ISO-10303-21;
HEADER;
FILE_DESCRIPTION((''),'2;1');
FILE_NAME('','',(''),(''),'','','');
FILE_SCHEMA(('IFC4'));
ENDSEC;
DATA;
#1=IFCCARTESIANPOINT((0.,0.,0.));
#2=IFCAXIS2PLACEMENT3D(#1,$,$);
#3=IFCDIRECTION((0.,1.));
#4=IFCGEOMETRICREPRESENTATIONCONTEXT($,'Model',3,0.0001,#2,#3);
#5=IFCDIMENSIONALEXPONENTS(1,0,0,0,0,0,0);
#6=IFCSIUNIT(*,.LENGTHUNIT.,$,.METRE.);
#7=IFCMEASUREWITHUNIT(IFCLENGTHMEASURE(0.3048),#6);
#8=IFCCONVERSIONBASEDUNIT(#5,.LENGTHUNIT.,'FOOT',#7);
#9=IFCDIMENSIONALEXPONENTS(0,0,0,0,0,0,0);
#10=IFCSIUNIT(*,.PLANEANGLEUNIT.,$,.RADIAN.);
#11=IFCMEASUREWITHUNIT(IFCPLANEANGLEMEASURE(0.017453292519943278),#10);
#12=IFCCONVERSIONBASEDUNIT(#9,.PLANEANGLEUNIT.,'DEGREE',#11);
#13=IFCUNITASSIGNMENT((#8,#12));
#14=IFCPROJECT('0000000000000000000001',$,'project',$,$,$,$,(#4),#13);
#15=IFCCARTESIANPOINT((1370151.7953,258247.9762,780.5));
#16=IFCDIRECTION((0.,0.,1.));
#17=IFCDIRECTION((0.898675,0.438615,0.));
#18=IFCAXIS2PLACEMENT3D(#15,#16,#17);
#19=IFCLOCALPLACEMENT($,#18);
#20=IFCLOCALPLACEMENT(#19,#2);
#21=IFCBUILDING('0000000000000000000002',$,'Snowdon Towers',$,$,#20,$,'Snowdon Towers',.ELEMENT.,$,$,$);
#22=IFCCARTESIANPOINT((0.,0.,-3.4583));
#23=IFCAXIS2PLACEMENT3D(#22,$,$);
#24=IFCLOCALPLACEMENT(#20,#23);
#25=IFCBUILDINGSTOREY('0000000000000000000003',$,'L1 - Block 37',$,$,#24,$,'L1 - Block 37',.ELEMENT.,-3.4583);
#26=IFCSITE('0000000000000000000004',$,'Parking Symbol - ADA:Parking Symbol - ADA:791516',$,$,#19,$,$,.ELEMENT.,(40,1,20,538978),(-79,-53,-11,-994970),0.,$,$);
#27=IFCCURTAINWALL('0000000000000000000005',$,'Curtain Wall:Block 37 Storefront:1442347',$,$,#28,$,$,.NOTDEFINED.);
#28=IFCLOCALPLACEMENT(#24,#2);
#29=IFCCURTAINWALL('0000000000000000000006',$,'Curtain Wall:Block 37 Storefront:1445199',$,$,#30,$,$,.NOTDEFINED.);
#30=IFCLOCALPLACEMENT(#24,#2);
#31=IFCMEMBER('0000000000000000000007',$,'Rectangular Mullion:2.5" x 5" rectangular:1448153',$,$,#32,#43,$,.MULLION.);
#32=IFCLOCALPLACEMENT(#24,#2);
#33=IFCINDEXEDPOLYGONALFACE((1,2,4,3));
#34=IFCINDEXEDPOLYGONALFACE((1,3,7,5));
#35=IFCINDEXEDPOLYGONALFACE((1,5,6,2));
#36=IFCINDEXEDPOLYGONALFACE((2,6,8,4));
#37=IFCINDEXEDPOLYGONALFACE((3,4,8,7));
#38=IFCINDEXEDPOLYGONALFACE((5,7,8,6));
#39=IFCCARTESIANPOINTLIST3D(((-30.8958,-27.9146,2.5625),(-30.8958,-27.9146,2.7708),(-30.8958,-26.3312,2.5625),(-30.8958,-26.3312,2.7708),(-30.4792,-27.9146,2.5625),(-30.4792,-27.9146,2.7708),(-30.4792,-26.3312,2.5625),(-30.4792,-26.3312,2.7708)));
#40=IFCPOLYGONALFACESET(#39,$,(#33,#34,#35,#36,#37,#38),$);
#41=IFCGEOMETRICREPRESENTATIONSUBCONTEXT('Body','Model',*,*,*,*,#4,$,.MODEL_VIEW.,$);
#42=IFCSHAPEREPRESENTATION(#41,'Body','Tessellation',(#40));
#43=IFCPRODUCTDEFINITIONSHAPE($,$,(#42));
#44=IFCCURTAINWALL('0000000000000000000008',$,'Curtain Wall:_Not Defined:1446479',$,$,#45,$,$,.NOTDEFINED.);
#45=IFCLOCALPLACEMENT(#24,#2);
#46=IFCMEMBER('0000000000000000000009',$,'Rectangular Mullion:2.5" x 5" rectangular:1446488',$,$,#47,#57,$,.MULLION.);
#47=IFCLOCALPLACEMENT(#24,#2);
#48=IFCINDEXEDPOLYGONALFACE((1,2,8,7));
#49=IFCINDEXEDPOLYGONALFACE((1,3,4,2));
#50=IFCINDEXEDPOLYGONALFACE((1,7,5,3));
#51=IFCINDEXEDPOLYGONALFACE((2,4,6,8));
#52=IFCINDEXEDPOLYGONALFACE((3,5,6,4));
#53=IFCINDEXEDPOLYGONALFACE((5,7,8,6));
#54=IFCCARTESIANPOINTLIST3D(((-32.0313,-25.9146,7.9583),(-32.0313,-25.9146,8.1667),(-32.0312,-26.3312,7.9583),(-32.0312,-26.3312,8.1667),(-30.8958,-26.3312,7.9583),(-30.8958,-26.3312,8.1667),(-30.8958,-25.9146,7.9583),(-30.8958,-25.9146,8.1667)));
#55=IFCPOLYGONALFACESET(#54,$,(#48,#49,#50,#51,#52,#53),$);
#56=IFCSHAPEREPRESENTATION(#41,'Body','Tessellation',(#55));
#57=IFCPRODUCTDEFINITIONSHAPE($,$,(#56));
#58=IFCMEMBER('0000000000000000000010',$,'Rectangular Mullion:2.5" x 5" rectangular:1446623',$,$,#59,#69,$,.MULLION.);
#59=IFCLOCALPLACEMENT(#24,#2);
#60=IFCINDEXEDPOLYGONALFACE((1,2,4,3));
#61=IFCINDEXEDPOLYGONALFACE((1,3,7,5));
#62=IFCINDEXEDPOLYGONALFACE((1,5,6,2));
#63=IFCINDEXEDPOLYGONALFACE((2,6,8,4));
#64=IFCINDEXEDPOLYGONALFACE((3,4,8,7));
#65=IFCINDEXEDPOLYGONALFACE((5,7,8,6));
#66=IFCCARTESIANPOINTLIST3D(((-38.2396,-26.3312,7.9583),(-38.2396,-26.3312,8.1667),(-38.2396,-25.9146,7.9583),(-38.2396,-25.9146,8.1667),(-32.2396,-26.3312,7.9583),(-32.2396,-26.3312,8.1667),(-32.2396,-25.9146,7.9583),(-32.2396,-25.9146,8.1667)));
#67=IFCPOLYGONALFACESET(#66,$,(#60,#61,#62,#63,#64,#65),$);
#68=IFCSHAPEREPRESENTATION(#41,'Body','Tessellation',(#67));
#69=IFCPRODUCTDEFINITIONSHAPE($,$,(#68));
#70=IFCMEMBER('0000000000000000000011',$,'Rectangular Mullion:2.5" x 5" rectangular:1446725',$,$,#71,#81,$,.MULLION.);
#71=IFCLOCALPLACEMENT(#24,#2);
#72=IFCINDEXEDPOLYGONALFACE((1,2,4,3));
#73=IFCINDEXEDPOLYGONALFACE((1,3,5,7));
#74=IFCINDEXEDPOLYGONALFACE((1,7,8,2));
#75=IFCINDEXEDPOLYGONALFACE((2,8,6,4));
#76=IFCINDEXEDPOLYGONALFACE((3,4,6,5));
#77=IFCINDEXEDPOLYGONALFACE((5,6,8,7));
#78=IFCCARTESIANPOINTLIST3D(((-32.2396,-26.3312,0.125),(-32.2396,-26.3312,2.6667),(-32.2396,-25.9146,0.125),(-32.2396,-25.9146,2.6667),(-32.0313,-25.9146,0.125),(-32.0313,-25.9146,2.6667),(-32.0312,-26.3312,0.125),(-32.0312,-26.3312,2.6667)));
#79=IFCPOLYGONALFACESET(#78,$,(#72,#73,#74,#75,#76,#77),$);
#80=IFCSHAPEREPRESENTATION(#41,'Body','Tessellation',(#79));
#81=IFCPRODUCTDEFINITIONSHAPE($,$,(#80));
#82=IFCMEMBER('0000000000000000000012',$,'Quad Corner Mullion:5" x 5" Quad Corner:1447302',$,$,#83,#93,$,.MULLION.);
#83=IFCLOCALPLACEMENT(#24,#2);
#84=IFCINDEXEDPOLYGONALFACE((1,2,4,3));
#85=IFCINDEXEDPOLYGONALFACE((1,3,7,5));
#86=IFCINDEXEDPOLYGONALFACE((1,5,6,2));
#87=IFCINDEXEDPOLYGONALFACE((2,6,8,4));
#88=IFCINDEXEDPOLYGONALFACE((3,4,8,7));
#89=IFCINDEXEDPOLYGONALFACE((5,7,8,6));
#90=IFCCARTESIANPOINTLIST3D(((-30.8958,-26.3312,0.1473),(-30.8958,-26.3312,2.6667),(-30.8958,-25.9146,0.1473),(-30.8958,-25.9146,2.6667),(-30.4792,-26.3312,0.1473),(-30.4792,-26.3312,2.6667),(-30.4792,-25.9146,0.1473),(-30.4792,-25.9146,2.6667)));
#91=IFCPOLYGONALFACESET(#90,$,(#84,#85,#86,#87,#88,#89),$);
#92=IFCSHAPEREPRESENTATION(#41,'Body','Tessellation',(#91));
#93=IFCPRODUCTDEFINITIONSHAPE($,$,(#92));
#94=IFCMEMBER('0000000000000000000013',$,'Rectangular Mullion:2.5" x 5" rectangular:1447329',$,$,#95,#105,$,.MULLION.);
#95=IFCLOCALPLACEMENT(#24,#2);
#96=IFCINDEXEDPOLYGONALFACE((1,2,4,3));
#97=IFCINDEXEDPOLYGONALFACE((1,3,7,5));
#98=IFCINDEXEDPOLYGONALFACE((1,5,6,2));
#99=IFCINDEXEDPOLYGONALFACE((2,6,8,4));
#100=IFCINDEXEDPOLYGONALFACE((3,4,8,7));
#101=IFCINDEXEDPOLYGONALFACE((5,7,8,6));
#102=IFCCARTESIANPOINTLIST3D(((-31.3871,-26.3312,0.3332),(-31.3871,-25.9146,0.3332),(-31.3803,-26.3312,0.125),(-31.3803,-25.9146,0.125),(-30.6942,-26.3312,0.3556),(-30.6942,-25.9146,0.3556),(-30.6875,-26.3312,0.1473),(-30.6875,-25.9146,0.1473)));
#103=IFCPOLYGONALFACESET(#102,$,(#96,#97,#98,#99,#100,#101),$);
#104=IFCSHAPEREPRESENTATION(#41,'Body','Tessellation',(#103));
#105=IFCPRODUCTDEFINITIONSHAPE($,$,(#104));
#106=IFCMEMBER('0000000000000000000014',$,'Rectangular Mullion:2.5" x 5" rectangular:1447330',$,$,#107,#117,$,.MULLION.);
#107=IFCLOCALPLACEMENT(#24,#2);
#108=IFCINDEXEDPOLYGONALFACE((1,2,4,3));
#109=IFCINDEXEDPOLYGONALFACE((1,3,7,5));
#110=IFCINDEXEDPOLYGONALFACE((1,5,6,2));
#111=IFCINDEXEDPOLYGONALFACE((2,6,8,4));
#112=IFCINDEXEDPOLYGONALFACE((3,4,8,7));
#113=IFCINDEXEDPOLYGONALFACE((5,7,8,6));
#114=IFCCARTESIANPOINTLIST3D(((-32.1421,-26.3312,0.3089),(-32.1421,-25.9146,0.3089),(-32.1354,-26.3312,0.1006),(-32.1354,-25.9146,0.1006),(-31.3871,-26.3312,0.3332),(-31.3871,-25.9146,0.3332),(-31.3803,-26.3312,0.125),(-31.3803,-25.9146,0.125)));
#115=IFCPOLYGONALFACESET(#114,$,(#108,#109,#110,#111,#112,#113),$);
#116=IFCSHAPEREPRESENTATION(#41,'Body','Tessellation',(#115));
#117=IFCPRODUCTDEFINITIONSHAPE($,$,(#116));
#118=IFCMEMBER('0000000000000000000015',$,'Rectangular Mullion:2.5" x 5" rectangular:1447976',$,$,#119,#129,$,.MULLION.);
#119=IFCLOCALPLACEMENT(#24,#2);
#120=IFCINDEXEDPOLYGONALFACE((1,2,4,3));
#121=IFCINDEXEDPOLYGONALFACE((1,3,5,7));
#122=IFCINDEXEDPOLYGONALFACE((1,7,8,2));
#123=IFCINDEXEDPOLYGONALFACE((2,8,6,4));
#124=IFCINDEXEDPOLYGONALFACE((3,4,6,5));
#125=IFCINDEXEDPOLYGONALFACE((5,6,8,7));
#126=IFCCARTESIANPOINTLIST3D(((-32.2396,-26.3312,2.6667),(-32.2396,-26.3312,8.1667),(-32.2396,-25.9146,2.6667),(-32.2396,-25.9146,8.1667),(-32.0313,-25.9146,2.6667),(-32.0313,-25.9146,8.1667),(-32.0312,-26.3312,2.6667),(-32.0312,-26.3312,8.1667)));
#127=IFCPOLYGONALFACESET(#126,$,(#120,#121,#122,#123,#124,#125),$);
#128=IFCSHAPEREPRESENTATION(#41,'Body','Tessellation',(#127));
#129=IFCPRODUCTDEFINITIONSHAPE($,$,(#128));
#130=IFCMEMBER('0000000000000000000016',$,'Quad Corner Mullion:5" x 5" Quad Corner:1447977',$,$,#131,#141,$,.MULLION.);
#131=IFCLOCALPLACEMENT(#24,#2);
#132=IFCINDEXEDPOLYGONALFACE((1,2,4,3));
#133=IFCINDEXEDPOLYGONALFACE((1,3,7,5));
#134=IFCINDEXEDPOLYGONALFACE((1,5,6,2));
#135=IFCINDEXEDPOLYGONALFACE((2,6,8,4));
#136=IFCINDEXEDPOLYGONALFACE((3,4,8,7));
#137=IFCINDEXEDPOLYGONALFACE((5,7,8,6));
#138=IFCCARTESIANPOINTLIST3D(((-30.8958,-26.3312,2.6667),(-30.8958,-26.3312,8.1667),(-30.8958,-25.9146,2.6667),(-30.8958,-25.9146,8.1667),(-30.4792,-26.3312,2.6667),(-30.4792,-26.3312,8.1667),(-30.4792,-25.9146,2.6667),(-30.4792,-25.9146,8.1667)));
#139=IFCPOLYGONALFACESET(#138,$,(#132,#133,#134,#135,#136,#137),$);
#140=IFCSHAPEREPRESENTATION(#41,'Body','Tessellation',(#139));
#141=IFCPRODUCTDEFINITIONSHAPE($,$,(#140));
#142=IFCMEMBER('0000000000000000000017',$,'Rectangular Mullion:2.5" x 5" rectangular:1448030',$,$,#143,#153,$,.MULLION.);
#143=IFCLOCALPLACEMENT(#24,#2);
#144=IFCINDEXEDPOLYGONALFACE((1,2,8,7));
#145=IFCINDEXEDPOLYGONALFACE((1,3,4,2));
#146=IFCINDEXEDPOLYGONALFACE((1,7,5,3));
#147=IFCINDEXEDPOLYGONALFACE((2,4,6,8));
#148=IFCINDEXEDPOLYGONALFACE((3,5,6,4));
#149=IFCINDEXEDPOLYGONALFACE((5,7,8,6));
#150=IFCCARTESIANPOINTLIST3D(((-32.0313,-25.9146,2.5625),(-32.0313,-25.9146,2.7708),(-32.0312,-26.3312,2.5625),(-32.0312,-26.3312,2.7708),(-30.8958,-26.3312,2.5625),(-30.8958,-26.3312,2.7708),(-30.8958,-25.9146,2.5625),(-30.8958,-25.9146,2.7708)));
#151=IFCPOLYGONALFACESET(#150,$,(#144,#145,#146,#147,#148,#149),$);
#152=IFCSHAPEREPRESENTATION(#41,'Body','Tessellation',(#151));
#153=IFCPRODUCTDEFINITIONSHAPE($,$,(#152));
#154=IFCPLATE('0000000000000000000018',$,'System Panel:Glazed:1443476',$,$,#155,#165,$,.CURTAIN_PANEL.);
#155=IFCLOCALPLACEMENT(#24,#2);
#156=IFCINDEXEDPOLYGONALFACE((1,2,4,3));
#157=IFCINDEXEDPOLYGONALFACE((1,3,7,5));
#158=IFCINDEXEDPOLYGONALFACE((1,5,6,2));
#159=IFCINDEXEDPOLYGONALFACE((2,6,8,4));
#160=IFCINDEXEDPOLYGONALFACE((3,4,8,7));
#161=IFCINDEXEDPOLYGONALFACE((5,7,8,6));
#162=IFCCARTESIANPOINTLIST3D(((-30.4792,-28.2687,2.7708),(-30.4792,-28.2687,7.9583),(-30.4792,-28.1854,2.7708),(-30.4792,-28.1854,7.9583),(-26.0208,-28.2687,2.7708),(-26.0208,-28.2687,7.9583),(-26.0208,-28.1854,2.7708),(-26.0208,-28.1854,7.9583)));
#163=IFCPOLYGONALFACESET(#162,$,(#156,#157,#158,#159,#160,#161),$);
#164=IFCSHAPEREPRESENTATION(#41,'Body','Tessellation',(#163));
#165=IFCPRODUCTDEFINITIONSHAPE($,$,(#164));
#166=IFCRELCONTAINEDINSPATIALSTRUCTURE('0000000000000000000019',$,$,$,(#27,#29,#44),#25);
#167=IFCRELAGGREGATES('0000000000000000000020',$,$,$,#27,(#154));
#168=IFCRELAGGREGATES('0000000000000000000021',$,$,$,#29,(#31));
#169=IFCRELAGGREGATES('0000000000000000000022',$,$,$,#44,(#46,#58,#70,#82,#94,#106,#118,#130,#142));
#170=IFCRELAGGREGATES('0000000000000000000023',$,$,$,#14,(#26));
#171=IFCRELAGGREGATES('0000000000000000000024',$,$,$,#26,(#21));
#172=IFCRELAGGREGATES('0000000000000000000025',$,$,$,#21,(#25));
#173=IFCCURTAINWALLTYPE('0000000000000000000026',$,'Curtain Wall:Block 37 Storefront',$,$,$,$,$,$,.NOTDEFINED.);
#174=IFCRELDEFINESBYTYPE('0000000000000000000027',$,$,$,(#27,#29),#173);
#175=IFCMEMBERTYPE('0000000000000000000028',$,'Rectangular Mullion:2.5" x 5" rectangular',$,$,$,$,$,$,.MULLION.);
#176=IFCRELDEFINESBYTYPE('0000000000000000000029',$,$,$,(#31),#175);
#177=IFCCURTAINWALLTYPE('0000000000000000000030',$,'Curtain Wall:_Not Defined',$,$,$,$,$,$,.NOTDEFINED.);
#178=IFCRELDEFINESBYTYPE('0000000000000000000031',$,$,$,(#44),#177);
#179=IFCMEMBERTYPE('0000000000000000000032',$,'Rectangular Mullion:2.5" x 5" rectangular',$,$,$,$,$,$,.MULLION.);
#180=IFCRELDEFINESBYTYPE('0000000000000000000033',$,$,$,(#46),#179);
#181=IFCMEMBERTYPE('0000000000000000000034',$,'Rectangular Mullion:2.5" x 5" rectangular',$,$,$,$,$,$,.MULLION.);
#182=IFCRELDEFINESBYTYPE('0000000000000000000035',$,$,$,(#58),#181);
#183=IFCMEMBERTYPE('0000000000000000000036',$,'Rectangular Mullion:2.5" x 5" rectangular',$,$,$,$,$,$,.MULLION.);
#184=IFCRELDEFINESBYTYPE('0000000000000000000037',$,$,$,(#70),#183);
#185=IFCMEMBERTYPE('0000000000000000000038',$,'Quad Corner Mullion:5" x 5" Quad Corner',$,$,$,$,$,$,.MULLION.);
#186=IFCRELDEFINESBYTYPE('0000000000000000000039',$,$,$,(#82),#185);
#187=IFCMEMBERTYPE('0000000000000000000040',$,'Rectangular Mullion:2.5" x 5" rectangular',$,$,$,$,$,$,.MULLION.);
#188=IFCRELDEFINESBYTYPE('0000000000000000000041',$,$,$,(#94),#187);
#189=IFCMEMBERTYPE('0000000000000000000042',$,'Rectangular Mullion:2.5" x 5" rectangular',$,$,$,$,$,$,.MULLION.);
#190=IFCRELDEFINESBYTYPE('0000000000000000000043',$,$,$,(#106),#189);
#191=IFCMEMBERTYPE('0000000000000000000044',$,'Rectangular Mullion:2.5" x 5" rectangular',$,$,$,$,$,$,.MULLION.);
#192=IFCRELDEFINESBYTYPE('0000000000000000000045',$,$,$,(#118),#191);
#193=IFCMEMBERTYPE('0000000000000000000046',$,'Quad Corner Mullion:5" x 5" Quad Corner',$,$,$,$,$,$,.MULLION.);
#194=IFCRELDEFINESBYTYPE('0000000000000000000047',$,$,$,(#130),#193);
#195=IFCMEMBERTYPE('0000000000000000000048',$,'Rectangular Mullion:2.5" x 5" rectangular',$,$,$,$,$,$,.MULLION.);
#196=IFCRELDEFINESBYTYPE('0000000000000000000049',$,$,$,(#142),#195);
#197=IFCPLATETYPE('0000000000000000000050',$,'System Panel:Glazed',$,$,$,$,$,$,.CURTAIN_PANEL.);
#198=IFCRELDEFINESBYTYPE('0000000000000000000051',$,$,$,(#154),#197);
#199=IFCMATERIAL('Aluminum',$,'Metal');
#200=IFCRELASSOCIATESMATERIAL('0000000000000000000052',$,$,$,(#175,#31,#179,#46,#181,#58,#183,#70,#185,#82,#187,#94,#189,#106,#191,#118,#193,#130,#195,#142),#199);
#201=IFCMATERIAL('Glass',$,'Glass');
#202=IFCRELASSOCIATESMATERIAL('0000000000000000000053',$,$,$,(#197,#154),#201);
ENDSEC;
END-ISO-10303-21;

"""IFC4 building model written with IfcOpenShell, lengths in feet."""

from ifc_helpers import new_model, entity, si_unit, converted_unit, direction, frame, origin, place, context, subcontext, project, spatial, indexed_curve, outline, extrude, source, transform, mapped, material, type_object, type_shapes, element, aggregate, save


model = new_model("IFC4")

# Units and contexts
model_context = context("Model", 3, precision=0.0001, world=origin(), true_north=direction((0.0, 1.0)))
body_context = subcontext(model_context, "Body", "Model", "MODEL_VIEW")
ifc_project = project(units=[converted_unit("LENGTHUNIT", "FOOT", entity("IfcLengthMeasure", 0.3048), si_unit("LENGTHUNIT", "METRE"), dimensions=[1, 0, 0, 0, 0, 0, 0]), converted_unit("PLANEANGLEUNIT", "DEGREE", entity("IfcPlaneAngleMeasure", 0.017453292519943278), si_unit("PLANEANGLEUNIT", "RADIAN"), dimensions=[0, 0, 0, 0, 0, 0, 0])], contexts=[model_context])

# Site, building, storey
site_placement = place(None, frame((1370151.7953, 258247.9762, 780.5), z_axis=(0.0, 0.0, 1.0), x_axis=(0.898675, 0.438615, 0.0)))
site = spatial("IfcSite", under=ifc_project, at=site_placement, Name="Parking Symbol - ADA:Parking Symbol - ADA:791516", CompositionType="ELEMENT", RefLatitude=(40, 1, 20, 538978), RefLongitude=(-79, -53, -11, -994970), RefElevation=0.0)
building_placement = place(site_placement, origin())
building = spatial("IfcBuilding", under=site, at=building_placement, Name="Snowdon Towers", LongName="Snowdon Towers", CompositionType="ELEMENT")
storey_placement = place(building_placement, frame((0.0, 0.0, -3.4583)))
storey = spatial("IfcBuildingStorey", under=building, at=storey_placement, Name="L1 - Block 37", LongName="L1 - Block 37", CompositionType="ELEMENT", Elevation=-3.4583)

# Curtain walls, members
curtain_wall_type_1 = type_object("IfcCurtainWallType", Name="Curtain Wall:Block 37 Storefront", PredefinedType="NOTDEFINED")
curtain_wall_1_placement = place(storey_placement, frame((0.0, 0.0, 3.4583)))
curtain_wall_1 = element("IfcCurtainWall", 1, at=curtain_wall_1_placement, inside=storey, type_object=curtain_wall_type_1, Name="Curtain Wall:Block 37 Storefront:1442347", PredefinedType="NOTDEFINED")
ifc_material_1 = material(Name="Aluminum", Category="Metal")
curtain_wall_2_placement = place(storey_placement, frame((0.0, 0.0, 3.4583)))
curtain_wall_2 = element("IfcCurtainWall", 2, at=curtain_wall_2_placement, inside=storey, type_object=curtain_wall_type_1, Name="Curtain Wall:Block 37 Storefront:1445199", PredefinedType="NOTDEFINED")
member_type_1 = type_object("IfcMemberType", Name="Rectangular Mullion:2.5\" x 5\" rectangular", PredefinedType="MULLION", material=ifc_material_1)
shared_shape_1 = source(origin(), body_context, "Body", "SweptSolid", [
    extrude(outline(indexed_curve([(-0.1042, -0.2083), (0.1042, -0.2083), (0.1042, 0.2083), (-0.1042, 0.2083), (-0.1042, -0.2083)], self_intersect=False)), frame((0.0, 0.0, -1.5833), z_axis=(0.0, 0.0, 1.0), x_axis=(-1.0, 0.0, 0.0)), (0.0, 0.0, 1.0), 1.5833),
])
type_shapes(member_type_1, [shared_shape_1])
member_1_placement = place(curtain_wall_2_placement, frame((-30.6875, -27.9146, -0.7917), z_axis=(0.0, -1.0, 0.0), x_axis=(0.0, 0.0, 1.0)))
member_1 = element("IfcMember", 3, at=member_1_placement, type_object=member_type_1, material=ifc_material_1, Name="Rectangular Mullion:2.5\" x 5\" rectangular:1448153", PredefinedType="MULLION", context=body_context, shape_type="MappedRepresentation", body=[
    mapped(shared_shape_1, transform((0.0, 0.0, 0.0), scale=1.0)),
])
curtain_wall_type_2 = type_object("IfcCurtainWallType", Name="Curtain Wall:_Not Defined", PredefinedType="NOTDEFINED")
curtain_wall_3_placement = place(storey_placement, frame((0.0, 0.0, 3.4583)))
curtain_wall_3 = element("IfcCurtainWall", 4, at=curtain_wall_3_placement, inside=storey, type_object=curtain_wall_type_2, Name="Curtain Wall:_Not Defined:1446479", PredefinedType="NOTDEFINED")
member_type_2 = type_object("IfcMemberType", Name="Rectangular Mullion:2.5\" x 5\" rectangular", PredefinedType="MULLION", material=ifc_material_1)
shared_shape_2 = source(origin(), body_context, "Body", "SweptSolid", [
    extrude(outline(indexed_curve([(-0.1042, -0.2083), (0.1042, -0.2083), (0.1042, 0.2083), (-0.1042, 0.2083), (-0.1042, -0.2083)], self_intersect=False)), frame((-0.1042, 0.0, -1.1354), z_axis=(0.0, 0.0, 1.0), x_axis=(-1.0, 0.0, 0.0)), (0.0, 0.0, 1.0), 1.1354),
])
type_shapes(member_type_2, [shared_shape_2])
member_2_placement = place(curtain_wall_3_placement, frame((-30.8958, -26.1229, 4.7083), z_axis=(1.0, 0.0, 0.0), x_axis=(0.0, 0.0, 1.0)))
member_2 = element("IfcMember", 5, at=member_2_placement, type_object=member_type_2, material=ifc_material_1, Name="Rectangular Mullion:2.5\" x 5\" rectangular:1446488", PredefinedType="MULLION", context=body_context, shape_type="MappedRepresentation", body=[
    mapped(shared_shape_2, transform((0.0, 0.0, 0.0), scale=1.0)),
])
member_type_3 = type_object("IfcMemberType", Name="Rectangular Mullion:2.5\" x 5\" rectangular", PredefinedType="MULLION", material=ifc_material_1)
shared_shape_3 = source(origin(), body_context, "Body", "SweptSolid", [
    extrude(outline(indexed_curve([(-0.1042, -0.2083), (0.1042, -0.2083), (0.1042, 0.2083), (-0.1042, 0.2083), (-0.1042, -0.2083)], self_intersect=False)), frame((-0.1042, 0.0, -6.0), z_axis=(0.0, 0.0, 1.0), x_axis=(-1.0, 0.0, 0.0)), (0.0, 0.0, 1.0), 6.0),
])
type_shapes(member_type_3, [shared_shape_3])
member_3_placement = place(curtain_wall_3_placement, frame((-32.2396, -26.1229, 4.7083), z_axis=(1.0, 0.0, 0.0), x_axis=(0.0, 0.0, 1.0)))
member_3 = element("IfcMember", 6, at=member_3_placement, type_object=member_type_3, material=ifc_material_1, Name="Rectangular Mullion:2.5\" x 5\" rectangular:1446623", PredefinedType="MULLION", context=body_context, shape_type="MappedRepresentation", body=[
    mapped(shared_shape_3, transform((0.0, 0.0, 0.0), scale=1.0)),
])
member_type_4 = type_object("IfcMemberType", Name="Rectangular Mullion:2.5\" x 5\" rectangular", PredefinedType="MULLION", material=ifc_material_1)
shared_shape_4 = source(origin(), body_context, "Body", "SweptSolid", [
    extrude(outline(indexed_curve([(-0.1042, -0.2083), (0.1042, -0.2083), (0.1042, 0.2083), (-0.1042, 0.2083), (-0.1042, -0.2083)], self_intersect=False)), frame((0.0, 0.0, -2.5417), z_axis=(0.0, 0.0, 1.0), x_axis=(-1.0, 0.0, 0.0)), (0.0, 0.0, 1.0), 2.5417),
])
type_shapes(member_type_4, [shared_shape_4])
member_4_placement = place(curtain_wall_3_placement, frame((-32.1354, -26.1229, -3.3333), z_axis=(0.0, 0.0, -1.0), x_axis=(1.0, 0.0, 0.0)))
member_4 = element("IfcMember", 7, at=member_4_placement, type_object=member_type_4, material=ifc_material_1, Name="Rectangular Mullion:2.5\" x 5\" rectangular:1446725", PredefinedType="MULLION", context=body_context, shape_type="MappedRepresentation", body=[
    mapped(shared_shape_4, transform((0.0, 0.0, 0.0), scale=1.0)),
])
member_type_5 = type_object("IfcMemberType", Name="Quad Corner Mullion:5\" x 5\" Quad Corner", PredefinedType="MULLION", material=ifc_material_1)
shared_shape_5 = source(origin(), body_context, "Body", "SweptSolid", [
    extrude(outline(indexed_curve([(-0.2083, -0.2083), (0.2083, -0.2083), (0.2083, 0.2083), (-0.2083, 0.2083), (-0.2083, -0.2083)], self_intersect=False)), frame((0.0, 0.0, -2.5193), z_axis=(0.0, 0.0, 1.0), x_axis=(-1.0, 0.0, 0.0)), (0.0, 0.0, 1.0), 2.5193),
])
type_shapes(member_type_5, [shared_shape_5])
member_5_placement = place(curtain_wall_3_placement, frame((-30.6875, -26.1229, -3.311), z_axis=(0.0, 0.0, -1.0), x_axis=(1.0, 0.0, 0.0)))
member_5 = element("IfcMember", 8, at=member_5_placement, type_object=member_type_5, material=ifc_material_1, Name="Quad Corner Mullion:5\" x 5\" Quad Corner:1447302", PredefinedType="MULLION", context=body_context, shape_type="MappedRepresentation", body=[
    mapped(shared_shape_5, transform((0.0, 0.0, 0.0), scale=1.0)),
])
member_type_6 = type_object("IfcMemberType", Name="Rectangular Mullion:2.5\" x 5\" rectangular", PredefinedType="MULLION", material=ifc_material_1)
shared_shape_6 = source(origin(), body_context, "Body", "SweptSolid", [
    extrude(outline(indexed_curve([(-0.3466, -0.2083), (0.3466, -0.2083), (0.3466, 0.2083), (-0.3466, 0.2083), (-0.3466, -0.2083)], self_intersect=False)), frame((-0.2083, 0.0, -0.3466), z_axis=(1.0, 0.0, 0.0), x_axis=(0.0, 0.0, -1.0)), (0.0, 0.0, 1.0), 0.2083),
])
type_shapes(member_type_6, [shared_shape_6])
member_6_placement = place(curtain_wall_3_placement, frame((-31.3803, -26.1229, -3.3333), z_axis=(-0.99948, 0.0, -0.032241), x_axis=(0.032241, 0.0, -0.99948)))
member_6 = element("IfcMember", 9, at=member_6_placement, type_object=member_type_6, material=ifc_material_1, Name="Rectangular Mullion:2.5\" x 5\" rectangular:1447329", PredefinedType="MULLION", context=body_context, shape_type="MappedRepresentation", body=[
    mapped(shared_shape_6, transform((0.0, 0.0, 0.0), scale=1.0)),
])
member_type_7 = type_object("IfcMemberType", Name="Rectangular Mullion:2.5\" x 5\" rectangular", PredefinedType="MULLION", material=ifc_material_1)
shared_shape_7 = source(origin(), body_context, "Body", "SweptSolid", [
    extrude(outline(indexed_curve([(-0.3777, -0.2083), (0.3777, -0.2083), (0.3777, 0.2083), (-0.3777, 0.2083), (-0.3777, -0.2083)], self_intersect=False)), frame((-0.2083, 0.0, -0.3777), z_axis=(1.0, 0.0, 0.0), x_axis=(0.0, 0.0, -1.0)), (0.0, 0.0, 1.0), 0.2083),
])
type_shapes(member_type_7, [shared_shape_7])
member_7_placement = place(curtain_wall_3_placement, frame((-32.1354, -26.1229, -3.3577), z_axis=(-0.99948, 0.0, -0.032241), x_axis=(0.032241, 0.0, -0.99948)))
member_7 = element("IfcMember", 10, at=member_7_placement, type_object=member_type_7, material=ifc_material_1, Name="Rectangular Mullion:2.5\" x 5\" rectangular:1447330", PredefinedType="MULLION", context=body_context, shape_type="MappedRepresentation", body=[
    mapped(shared_shape_7, transform((0.0, 0.0, 0.0), scale=1.0)),
])
member_type_8 = type_object("IfcMemberType", Name="Rectangular Mullion:2.5\" x 5\" rectangular", PredefinedType="MULLION", material=ifc_material_1)
shared_shape_8 = source(origin(), body_context, "Body", "SweptSolid", [
    extrude(outline(indexed_curve([(-0.1042, -0.2083), (0.1042, -0.2083), (0.1042, 0.2083), (-0.1042, 0.2083), (-0.1042, -0.2083)], self_intersect=False)), frame((0.0, 0.0, -5.5), z_axis=(0.0, 0.0, 1.0), x_axis=(-1.0, 0.0, 0.0)), (0.0, 0.0, 1.0), 5.5),
])
type_shapes(member_type_8, [shared_shape_8])
member_8_placement = place(curtain_wall_3_placement, frame((-32.1354, -26.1229, -0.7917), z_axis=(0.0, 0.0, -1.0), x_axis=(1.0, 0.0, 0.0)))
member_8 = element("IfcMember", 11, at=member_8_placement, type_object=member_type_8, material=ifc_material_1, Name="Rectangular Mullion:2.5\" x 5\" rectangular:1447976", PredefinedType="MULLION", context=body_context, shape_type="MappedRepresentation", body=[
    mapped(shared_shape_8, transform((0.0, 0.0, 0.0), scale=1.0)),
])
member_type_9 = type_object("IfcMemberType", Name="Quad Corner Mullion:5\" x 5\" Quad Corner", PredefinedType="MULLION", material=ifc_material_1)
shared_shape_9 = source(origin(), body_context, "Body", "SweptSolid", [
    extrude(outline(indexed_curve([(-0.2083, -0.2083), (0.2083, -0.2083), (0.2083, 0.2083), (-0.2083, 0.2083), (-0.2083, -0.2083)], self_intersect=False)), frame((0.0, 0.0, -5.5), z_axis=(0.0, 0.0, 1.0), x_axis=(-1.0, 0.0, 0.0)), (0.0, 0.0, 1.0), 5.5),
])
type_shapes(member_type_9, [shared_shape_9])
member_9_placement = place(curtain_wall_3_placement, frame((-30.6875, -26.1229, -0.7917), z_axis=(0.0, 0.0, -1.0), x_axis=(1.0, 0.0, 0.0)))
member_9 = element("IfcMember", 12, at=member_9_placement, type_object=member_type_9, material=ifc_material_1, Name="Quad Corner Mullion:5\" x 5\" Quad Corner:1447977", PredefinedType="MULLION", context=body_context, shape_type="MappedRepresentation", body=[
    mapped(shared_shape_9, transform((0.0, 0.0, 0.0), scale=1.0)),
])
member_type_10 = type_object("IfcMemberType", Name="Rectangular Mullion:2.5\" x 5\" rectangular", PredefinedType="MULLION", material=ifc_material_1)
shared_shape_10 = source(origin(), body_context, "Body", "SweptSolid", [
    extrude(outline(indexed_curve([(-0.1042, -0.2083), (0.1042, -0.2083), (0.1042, 0.2083), (-0.1042, 0.2083), (-0.1042, -0.2083)], self_intersect=False)), frame((0.0, 0.0, -1.1354), z_axis=(0.0, 0.0, 1.0), x_axis=(-1.0, 0.0, 0.0)), (0.0, 0.0, 1.0), 1.1354),
])
type_shapes(member_type_10, [shared_shape_10])
member_10_placement = place(curtain_wall_3_placement, frame((-30.8958, -26.1229, -0.7917), z_axis=(1.0, 0.0, 0.0), x_axis=(0.0, 0.0, 1.0)))
member_10 = element("IfcMember", 13, at=member_10_placement, type_object=member_type_10, material=ifc_material_1, Name="Rectangular Mullion:2.5\" x 5\" rectangular:1448030", PredefinedType="MULLION", context=body_context, shape_type="MappedRepresentation", body=[
    mapped(shared_shape_10, transform((0.0, 0.0, 0.0), scale=1.0)),
])

# Plate
ifc_material_2 = material(Name="Glass", Category="Glass")
plate_type_1 = type_object("IfcPlateType", Name="System Panel:Glazed", PredefinedType="CURTAIN_PANEL", material=ifc_material_2)
shared_shape_11 = source(origin(), body_context, "Body", "SweptSolid", [
    extrude(outline(indexed_curve([(-0.0417, -2.2292), (0.0417, -2.2292), (0.0417, 2.2292), (-0.0417, 2.2292), (-0.0417, -2.2292)], self_intersect=False)), frame((0.0, -0.1042, 0.0), z_axis=(0.0, 0.0, 1.0), x_axis=(0.0, 1.0, 0.0)), (0.0, 0.0, 1.0), 5.1875),
])
type_shapes(plate_type_1, [shared_shape_11])
plate_1_placement = place(curtain_wall_1_placement, frame((-28.25, -28.1229, -0.6875)))
plate_1 = element("IfcPlate", 14, at=plate_1_placement, type_object=plate_type_1, material=ifc_material_2, Name="System Panel:Glazed:1443476", PredefinedType="CURTAIN_PANEL", context=body_context, shape_type="MappedRepresentation", body=[
    mapped(shared_shape_11, transform((0.0, 0.0, 0.0), scale=1.0)),
])
aggregate(curtain_wall_1, [plate_1])
aggregate(curtain_wall_2, [member_1])
aggregate(curtain_wall_3, [member_2, member_3, member_4, member_5, member_6, member_7, member_8, member_9, member_10])

save(model, "model.ifc")
